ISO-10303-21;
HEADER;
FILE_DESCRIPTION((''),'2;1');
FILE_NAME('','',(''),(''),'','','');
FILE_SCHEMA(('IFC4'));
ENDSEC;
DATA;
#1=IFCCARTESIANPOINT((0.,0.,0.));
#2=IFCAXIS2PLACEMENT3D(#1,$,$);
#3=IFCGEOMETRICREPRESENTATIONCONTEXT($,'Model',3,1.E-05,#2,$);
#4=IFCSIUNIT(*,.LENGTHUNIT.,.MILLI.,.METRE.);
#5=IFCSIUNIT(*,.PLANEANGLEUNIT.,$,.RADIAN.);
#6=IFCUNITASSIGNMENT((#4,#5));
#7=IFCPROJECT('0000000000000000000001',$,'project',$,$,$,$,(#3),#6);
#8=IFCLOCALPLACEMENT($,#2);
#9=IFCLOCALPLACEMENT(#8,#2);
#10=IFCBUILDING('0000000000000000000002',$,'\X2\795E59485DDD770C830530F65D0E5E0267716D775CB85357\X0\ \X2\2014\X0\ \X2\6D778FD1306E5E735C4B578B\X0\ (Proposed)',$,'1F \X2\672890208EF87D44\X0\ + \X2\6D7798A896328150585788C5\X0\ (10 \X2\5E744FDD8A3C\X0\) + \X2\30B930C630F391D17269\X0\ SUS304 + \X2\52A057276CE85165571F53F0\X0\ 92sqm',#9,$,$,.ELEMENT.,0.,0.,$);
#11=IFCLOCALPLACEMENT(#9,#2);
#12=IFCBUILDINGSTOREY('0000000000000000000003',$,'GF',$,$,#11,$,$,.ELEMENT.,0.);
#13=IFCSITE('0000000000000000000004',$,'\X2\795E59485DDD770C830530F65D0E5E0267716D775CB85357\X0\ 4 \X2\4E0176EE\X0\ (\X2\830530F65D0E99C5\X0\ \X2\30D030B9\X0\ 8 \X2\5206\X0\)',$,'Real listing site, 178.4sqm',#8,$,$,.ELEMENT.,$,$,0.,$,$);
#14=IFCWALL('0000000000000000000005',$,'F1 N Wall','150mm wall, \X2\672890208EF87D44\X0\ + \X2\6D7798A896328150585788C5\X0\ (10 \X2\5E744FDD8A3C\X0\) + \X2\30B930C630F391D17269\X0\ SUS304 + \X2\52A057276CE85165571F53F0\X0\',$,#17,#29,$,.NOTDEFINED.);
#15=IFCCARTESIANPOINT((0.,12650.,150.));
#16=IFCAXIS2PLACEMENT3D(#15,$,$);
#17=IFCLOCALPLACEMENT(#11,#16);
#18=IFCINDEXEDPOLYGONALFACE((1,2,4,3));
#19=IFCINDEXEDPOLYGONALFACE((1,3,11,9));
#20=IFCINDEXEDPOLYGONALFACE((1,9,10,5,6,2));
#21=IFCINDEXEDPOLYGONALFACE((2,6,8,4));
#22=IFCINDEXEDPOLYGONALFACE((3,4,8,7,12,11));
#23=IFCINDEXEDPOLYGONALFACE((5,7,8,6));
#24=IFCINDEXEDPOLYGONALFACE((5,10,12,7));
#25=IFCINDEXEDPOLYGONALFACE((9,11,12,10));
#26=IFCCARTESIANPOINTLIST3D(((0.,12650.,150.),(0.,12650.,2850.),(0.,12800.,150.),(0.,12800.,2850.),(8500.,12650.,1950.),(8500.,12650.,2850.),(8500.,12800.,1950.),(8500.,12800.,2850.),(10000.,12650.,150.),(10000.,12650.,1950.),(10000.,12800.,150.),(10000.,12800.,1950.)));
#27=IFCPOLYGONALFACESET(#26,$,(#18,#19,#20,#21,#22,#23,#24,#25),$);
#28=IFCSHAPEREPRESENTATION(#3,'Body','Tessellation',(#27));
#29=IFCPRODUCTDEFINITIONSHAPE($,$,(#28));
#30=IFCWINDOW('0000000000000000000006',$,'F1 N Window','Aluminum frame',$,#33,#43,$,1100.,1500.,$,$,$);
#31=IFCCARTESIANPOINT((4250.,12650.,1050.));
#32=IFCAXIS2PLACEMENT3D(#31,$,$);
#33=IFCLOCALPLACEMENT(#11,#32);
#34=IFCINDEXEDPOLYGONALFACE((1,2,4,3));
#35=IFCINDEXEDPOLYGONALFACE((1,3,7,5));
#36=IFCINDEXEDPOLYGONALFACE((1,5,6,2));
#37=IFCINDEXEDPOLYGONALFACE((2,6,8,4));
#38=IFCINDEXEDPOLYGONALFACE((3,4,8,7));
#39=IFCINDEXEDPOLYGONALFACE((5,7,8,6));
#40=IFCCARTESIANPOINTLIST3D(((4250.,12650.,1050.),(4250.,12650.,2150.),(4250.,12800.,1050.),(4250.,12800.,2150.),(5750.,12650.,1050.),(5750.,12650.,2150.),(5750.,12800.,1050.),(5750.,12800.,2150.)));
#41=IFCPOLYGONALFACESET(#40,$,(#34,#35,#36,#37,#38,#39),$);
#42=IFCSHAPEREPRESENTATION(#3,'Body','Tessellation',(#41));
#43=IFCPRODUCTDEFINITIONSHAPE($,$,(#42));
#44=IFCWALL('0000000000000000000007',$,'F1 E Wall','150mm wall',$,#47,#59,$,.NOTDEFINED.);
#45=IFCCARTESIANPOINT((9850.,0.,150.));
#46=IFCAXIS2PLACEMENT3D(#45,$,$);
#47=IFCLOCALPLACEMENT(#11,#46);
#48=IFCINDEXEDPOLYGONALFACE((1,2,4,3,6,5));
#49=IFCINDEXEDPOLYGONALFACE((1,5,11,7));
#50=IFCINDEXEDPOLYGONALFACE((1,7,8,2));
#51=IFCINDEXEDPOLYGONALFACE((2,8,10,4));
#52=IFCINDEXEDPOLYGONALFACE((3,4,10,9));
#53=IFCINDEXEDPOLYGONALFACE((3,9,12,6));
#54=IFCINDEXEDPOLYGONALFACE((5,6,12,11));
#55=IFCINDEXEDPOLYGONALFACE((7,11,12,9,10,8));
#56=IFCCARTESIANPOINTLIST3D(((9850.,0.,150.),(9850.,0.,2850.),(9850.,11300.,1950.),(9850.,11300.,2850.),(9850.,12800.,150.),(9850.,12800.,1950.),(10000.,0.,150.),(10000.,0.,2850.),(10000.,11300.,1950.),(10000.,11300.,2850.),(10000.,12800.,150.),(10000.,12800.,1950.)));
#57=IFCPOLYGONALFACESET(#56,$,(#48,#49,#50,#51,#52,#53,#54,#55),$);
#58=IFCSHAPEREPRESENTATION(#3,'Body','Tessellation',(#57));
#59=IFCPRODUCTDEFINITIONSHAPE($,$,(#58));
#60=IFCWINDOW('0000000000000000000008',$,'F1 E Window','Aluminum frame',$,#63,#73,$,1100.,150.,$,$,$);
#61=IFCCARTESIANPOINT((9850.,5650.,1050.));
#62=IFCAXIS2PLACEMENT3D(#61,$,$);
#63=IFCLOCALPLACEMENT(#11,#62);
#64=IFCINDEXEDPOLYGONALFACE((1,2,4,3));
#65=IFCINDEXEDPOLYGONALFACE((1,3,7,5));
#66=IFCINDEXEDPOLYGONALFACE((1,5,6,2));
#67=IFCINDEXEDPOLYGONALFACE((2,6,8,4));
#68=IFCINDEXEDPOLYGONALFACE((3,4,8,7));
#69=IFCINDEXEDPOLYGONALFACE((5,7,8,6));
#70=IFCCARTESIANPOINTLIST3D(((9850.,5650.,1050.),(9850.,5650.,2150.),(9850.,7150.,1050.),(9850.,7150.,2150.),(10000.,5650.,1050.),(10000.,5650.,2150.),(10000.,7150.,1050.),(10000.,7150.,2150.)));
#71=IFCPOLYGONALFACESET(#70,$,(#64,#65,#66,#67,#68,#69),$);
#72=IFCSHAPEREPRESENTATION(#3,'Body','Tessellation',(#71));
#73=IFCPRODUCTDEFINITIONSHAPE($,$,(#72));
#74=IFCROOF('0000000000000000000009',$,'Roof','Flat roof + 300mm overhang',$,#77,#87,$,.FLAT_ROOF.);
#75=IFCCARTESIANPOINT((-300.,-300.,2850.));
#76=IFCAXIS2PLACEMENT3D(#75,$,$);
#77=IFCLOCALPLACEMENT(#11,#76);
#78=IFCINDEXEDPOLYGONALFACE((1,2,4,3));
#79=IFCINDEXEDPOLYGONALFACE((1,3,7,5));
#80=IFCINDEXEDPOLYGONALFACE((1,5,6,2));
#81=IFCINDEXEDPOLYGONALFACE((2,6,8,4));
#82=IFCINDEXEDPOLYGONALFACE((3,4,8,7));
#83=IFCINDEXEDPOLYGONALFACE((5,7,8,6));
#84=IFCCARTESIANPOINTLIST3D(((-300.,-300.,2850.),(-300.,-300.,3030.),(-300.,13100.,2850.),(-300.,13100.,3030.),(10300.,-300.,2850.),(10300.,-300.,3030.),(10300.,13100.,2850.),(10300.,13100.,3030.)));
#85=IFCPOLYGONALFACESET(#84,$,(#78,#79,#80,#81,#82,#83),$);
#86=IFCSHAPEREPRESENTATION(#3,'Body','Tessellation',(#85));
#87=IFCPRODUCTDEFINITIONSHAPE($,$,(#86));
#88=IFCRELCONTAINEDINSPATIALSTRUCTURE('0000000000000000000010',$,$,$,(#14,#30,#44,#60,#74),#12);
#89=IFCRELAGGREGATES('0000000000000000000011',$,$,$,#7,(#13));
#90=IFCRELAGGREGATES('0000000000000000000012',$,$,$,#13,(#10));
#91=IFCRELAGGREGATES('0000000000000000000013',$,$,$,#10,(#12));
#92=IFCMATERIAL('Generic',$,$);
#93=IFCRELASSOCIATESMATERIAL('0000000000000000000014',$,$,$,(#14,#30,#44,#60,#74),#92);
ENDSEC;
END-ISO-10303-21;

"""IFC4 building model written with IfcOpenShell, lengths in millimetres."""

from ifc_helpers import new_model, si_unit, frame, frame_2d, origin, place, context, project, spatial, rectangle, extrude, material, element, fill, save


model = new_model("IFC4")

# Units and contexts
model_context = context("Model", 3, precision=1e-05, world=origin())
ifc_project = project(units=[si_unit("LENGTHUNIT", "METRE", prefix="MILLI"), si_unit("PLANEANGLEUNIT", "RADIAN")], contexts=[model_context])

# Site, building, storey
site_placement = place(None, origin())
site = spatial("IfcSite", under=ifc_project, at=site_placement, Name="神奈川県茅ヶ崎市東海岸南 4 丁目 (茅ヶ崎駅 バス 8 分)", ObjectType="Real listing site, 178.4sqm", CompositionType="ELEMENT", RefElevation=0.0)
building_placement = place(site_placement, origin())
building = spatial("IfcBuilding", under=site, at=building_placement, Name="神奈川県茅ヶ崎市東海岸南 — 海近の平屋型 (Proposed)", ObjectType="1F 木造軸組 + 海風防腐塗装 (10 年保証) + ステン金物 SUS304 + 加圧注入土台 92sqm", CompositionType="ELEMENT", ElevationOfRefHeight=0.0, ElevationOfTerrain=0.0)
storey_placement = place(building_placement, origin())
storey = spatial("IfcBuildingStorey", under=building, at=storey_placement, Name="GF", CompositionType="ELEMENT", Elevation=0.0)

# Wall, opening, window
ifc_material_1 = material(Name="Generic")
wall_1_placement = place(storey_placement, frame((0.0, 12650.0, 150.0)))
wall_1 = element("IfcWall", 1, at=wall_1_placement, inside=storey, material=ifc_material_1, Name="F1 N Wall", Description="150mm wall, 木造軸組 + 海風防腐塗装 (10 年保証) + ステン金物 SUS304 + 加圧注入土台", PredefinedType="NOTDEFINED", context=model_context, shape_type="SweptSolid", body=[
    extrude(rectangle(XDim=10000.0, YDim=150.0, at=frame_2d((5000.0, 75.0))), frame((0.0, 12650.0, 150.0)), (0.0, 0.0, 1.0), 2700.0),
])
opening_1_placement = place(storey_placement, frame((4250.0, 12650.0, 1050.0)))
opening_1 = element("IfcOpeningElement", 2, at=opening_1_placement, cuts=wall_1, PredefinedType="NOTDEFINED", context=model_context, shape_type="SweptSolid", body=[
    extrude(rectangle(XDim=1500.0, YDim=150.0, at=frame_2d((750.0, 75.0))), frame((4250.0, 12650.0, 1050.0)), (0.0, 0.0, 1.0), 1100.0),
])
window_1_placement = place(storey_placement, frame((4250.0, 12650.0, 1050.0)))
window_1 = element("IfcWindow", 3, at=window_1_placement, inside=storey, material=ifc_material_1, Name="F1 N Window", Description="Aluminum frame", OverallHeight=1100.0, OverallWidth=1500.0, context=model_context, shape_type="SweptSolid", body=[
    extrude(rectangle(XDim=1500.0, YDim=150.0, at=frame_2d((750.0, 75.0))), frame((4250.0, 12650.0, 1050.0)), (0.0, 0.0, 1.0), 1100.0),
])
fill(opening_1, window_1)

# Wall, opening, window
wall_2_placement = place(storey_placement, frame((9850.0, 0.0, 150.0)))
wall_2 = element("IfcWall", 4, at=wall_2_placement, inside=storey, material=ifc_material_1, Name="F1 E Wall", Description="150mm wall", PredefinedType="NOTDEFINED", context=model_context, shape_type="SweptSolid", body=[
    extrude(rectangle(XDim=150.0, YDim=12800.0, at=frame_2d((75.0, 6400.0))), frame((9850.0, 0.0, 150.0)), (0.0, 0.0, 1.0), 2700.0),
])
opening_2_placement = place(storey_placement, frame((9850.0, 5650.0, 1050.0)))
opening_2 = element("IfcOpeningElement", 5, at=opening_2_placement, cuts=wall_2, PredefinedType="NOTDEFINED", context=model_context, shape_type="SweptSolid", body=[
    extrude(rectangle(XDim=150.0, YDim=1500.0, at=frame_2d((75.0, 750.0))), frame((9850.0, 5650.0, 1050.0)), (0.0, 0.0, 1.0), 1100.0),
])
window_2_placement = place(storey_placement, frame((9850.0, 5650.0, 1050.0)))
window_2 = element("IfcWindow", 6, at=window_2_placement, inside=storey, material=ifc_material_1, Name="F1 E Window", Description="Aluminum frame", OverallHeight=1100.0, OverallWidth=150.0, context=model_context, shape_type="SweptSolid", body=[
    extrude(rectangle(XDim=150.0, YDim=1500.0, at=frame_2d((75.0, 750.0))), frame((9850.0, 5650.0, 1050.0)), (0.0, 0.0, 1.0), 1100.0),
])
fill(opening_2, window_2)

# Roof
roof_placement = place(storey_placement, frame((-300.0, -300.0, 2850.0)))
element("IfcRoof", 7, at=roof_placement, inside=storey, material=ifc_material_1, Name="Roof", Description="Flat roof + 300mm overhang", PredefinedType="FLAT_ROOF", context=model_context, shape_type="SweptSolid", body=[
    extrude(rectangle(XDim=10600.0, YDim=13400.0, at=frame_2d((5300.0, 6700.0))), frame((-300.0, -300.0, 2850.0)), (0.0, 0.0, 1.0), 180.0),
])

save(model, "model.ifc")
